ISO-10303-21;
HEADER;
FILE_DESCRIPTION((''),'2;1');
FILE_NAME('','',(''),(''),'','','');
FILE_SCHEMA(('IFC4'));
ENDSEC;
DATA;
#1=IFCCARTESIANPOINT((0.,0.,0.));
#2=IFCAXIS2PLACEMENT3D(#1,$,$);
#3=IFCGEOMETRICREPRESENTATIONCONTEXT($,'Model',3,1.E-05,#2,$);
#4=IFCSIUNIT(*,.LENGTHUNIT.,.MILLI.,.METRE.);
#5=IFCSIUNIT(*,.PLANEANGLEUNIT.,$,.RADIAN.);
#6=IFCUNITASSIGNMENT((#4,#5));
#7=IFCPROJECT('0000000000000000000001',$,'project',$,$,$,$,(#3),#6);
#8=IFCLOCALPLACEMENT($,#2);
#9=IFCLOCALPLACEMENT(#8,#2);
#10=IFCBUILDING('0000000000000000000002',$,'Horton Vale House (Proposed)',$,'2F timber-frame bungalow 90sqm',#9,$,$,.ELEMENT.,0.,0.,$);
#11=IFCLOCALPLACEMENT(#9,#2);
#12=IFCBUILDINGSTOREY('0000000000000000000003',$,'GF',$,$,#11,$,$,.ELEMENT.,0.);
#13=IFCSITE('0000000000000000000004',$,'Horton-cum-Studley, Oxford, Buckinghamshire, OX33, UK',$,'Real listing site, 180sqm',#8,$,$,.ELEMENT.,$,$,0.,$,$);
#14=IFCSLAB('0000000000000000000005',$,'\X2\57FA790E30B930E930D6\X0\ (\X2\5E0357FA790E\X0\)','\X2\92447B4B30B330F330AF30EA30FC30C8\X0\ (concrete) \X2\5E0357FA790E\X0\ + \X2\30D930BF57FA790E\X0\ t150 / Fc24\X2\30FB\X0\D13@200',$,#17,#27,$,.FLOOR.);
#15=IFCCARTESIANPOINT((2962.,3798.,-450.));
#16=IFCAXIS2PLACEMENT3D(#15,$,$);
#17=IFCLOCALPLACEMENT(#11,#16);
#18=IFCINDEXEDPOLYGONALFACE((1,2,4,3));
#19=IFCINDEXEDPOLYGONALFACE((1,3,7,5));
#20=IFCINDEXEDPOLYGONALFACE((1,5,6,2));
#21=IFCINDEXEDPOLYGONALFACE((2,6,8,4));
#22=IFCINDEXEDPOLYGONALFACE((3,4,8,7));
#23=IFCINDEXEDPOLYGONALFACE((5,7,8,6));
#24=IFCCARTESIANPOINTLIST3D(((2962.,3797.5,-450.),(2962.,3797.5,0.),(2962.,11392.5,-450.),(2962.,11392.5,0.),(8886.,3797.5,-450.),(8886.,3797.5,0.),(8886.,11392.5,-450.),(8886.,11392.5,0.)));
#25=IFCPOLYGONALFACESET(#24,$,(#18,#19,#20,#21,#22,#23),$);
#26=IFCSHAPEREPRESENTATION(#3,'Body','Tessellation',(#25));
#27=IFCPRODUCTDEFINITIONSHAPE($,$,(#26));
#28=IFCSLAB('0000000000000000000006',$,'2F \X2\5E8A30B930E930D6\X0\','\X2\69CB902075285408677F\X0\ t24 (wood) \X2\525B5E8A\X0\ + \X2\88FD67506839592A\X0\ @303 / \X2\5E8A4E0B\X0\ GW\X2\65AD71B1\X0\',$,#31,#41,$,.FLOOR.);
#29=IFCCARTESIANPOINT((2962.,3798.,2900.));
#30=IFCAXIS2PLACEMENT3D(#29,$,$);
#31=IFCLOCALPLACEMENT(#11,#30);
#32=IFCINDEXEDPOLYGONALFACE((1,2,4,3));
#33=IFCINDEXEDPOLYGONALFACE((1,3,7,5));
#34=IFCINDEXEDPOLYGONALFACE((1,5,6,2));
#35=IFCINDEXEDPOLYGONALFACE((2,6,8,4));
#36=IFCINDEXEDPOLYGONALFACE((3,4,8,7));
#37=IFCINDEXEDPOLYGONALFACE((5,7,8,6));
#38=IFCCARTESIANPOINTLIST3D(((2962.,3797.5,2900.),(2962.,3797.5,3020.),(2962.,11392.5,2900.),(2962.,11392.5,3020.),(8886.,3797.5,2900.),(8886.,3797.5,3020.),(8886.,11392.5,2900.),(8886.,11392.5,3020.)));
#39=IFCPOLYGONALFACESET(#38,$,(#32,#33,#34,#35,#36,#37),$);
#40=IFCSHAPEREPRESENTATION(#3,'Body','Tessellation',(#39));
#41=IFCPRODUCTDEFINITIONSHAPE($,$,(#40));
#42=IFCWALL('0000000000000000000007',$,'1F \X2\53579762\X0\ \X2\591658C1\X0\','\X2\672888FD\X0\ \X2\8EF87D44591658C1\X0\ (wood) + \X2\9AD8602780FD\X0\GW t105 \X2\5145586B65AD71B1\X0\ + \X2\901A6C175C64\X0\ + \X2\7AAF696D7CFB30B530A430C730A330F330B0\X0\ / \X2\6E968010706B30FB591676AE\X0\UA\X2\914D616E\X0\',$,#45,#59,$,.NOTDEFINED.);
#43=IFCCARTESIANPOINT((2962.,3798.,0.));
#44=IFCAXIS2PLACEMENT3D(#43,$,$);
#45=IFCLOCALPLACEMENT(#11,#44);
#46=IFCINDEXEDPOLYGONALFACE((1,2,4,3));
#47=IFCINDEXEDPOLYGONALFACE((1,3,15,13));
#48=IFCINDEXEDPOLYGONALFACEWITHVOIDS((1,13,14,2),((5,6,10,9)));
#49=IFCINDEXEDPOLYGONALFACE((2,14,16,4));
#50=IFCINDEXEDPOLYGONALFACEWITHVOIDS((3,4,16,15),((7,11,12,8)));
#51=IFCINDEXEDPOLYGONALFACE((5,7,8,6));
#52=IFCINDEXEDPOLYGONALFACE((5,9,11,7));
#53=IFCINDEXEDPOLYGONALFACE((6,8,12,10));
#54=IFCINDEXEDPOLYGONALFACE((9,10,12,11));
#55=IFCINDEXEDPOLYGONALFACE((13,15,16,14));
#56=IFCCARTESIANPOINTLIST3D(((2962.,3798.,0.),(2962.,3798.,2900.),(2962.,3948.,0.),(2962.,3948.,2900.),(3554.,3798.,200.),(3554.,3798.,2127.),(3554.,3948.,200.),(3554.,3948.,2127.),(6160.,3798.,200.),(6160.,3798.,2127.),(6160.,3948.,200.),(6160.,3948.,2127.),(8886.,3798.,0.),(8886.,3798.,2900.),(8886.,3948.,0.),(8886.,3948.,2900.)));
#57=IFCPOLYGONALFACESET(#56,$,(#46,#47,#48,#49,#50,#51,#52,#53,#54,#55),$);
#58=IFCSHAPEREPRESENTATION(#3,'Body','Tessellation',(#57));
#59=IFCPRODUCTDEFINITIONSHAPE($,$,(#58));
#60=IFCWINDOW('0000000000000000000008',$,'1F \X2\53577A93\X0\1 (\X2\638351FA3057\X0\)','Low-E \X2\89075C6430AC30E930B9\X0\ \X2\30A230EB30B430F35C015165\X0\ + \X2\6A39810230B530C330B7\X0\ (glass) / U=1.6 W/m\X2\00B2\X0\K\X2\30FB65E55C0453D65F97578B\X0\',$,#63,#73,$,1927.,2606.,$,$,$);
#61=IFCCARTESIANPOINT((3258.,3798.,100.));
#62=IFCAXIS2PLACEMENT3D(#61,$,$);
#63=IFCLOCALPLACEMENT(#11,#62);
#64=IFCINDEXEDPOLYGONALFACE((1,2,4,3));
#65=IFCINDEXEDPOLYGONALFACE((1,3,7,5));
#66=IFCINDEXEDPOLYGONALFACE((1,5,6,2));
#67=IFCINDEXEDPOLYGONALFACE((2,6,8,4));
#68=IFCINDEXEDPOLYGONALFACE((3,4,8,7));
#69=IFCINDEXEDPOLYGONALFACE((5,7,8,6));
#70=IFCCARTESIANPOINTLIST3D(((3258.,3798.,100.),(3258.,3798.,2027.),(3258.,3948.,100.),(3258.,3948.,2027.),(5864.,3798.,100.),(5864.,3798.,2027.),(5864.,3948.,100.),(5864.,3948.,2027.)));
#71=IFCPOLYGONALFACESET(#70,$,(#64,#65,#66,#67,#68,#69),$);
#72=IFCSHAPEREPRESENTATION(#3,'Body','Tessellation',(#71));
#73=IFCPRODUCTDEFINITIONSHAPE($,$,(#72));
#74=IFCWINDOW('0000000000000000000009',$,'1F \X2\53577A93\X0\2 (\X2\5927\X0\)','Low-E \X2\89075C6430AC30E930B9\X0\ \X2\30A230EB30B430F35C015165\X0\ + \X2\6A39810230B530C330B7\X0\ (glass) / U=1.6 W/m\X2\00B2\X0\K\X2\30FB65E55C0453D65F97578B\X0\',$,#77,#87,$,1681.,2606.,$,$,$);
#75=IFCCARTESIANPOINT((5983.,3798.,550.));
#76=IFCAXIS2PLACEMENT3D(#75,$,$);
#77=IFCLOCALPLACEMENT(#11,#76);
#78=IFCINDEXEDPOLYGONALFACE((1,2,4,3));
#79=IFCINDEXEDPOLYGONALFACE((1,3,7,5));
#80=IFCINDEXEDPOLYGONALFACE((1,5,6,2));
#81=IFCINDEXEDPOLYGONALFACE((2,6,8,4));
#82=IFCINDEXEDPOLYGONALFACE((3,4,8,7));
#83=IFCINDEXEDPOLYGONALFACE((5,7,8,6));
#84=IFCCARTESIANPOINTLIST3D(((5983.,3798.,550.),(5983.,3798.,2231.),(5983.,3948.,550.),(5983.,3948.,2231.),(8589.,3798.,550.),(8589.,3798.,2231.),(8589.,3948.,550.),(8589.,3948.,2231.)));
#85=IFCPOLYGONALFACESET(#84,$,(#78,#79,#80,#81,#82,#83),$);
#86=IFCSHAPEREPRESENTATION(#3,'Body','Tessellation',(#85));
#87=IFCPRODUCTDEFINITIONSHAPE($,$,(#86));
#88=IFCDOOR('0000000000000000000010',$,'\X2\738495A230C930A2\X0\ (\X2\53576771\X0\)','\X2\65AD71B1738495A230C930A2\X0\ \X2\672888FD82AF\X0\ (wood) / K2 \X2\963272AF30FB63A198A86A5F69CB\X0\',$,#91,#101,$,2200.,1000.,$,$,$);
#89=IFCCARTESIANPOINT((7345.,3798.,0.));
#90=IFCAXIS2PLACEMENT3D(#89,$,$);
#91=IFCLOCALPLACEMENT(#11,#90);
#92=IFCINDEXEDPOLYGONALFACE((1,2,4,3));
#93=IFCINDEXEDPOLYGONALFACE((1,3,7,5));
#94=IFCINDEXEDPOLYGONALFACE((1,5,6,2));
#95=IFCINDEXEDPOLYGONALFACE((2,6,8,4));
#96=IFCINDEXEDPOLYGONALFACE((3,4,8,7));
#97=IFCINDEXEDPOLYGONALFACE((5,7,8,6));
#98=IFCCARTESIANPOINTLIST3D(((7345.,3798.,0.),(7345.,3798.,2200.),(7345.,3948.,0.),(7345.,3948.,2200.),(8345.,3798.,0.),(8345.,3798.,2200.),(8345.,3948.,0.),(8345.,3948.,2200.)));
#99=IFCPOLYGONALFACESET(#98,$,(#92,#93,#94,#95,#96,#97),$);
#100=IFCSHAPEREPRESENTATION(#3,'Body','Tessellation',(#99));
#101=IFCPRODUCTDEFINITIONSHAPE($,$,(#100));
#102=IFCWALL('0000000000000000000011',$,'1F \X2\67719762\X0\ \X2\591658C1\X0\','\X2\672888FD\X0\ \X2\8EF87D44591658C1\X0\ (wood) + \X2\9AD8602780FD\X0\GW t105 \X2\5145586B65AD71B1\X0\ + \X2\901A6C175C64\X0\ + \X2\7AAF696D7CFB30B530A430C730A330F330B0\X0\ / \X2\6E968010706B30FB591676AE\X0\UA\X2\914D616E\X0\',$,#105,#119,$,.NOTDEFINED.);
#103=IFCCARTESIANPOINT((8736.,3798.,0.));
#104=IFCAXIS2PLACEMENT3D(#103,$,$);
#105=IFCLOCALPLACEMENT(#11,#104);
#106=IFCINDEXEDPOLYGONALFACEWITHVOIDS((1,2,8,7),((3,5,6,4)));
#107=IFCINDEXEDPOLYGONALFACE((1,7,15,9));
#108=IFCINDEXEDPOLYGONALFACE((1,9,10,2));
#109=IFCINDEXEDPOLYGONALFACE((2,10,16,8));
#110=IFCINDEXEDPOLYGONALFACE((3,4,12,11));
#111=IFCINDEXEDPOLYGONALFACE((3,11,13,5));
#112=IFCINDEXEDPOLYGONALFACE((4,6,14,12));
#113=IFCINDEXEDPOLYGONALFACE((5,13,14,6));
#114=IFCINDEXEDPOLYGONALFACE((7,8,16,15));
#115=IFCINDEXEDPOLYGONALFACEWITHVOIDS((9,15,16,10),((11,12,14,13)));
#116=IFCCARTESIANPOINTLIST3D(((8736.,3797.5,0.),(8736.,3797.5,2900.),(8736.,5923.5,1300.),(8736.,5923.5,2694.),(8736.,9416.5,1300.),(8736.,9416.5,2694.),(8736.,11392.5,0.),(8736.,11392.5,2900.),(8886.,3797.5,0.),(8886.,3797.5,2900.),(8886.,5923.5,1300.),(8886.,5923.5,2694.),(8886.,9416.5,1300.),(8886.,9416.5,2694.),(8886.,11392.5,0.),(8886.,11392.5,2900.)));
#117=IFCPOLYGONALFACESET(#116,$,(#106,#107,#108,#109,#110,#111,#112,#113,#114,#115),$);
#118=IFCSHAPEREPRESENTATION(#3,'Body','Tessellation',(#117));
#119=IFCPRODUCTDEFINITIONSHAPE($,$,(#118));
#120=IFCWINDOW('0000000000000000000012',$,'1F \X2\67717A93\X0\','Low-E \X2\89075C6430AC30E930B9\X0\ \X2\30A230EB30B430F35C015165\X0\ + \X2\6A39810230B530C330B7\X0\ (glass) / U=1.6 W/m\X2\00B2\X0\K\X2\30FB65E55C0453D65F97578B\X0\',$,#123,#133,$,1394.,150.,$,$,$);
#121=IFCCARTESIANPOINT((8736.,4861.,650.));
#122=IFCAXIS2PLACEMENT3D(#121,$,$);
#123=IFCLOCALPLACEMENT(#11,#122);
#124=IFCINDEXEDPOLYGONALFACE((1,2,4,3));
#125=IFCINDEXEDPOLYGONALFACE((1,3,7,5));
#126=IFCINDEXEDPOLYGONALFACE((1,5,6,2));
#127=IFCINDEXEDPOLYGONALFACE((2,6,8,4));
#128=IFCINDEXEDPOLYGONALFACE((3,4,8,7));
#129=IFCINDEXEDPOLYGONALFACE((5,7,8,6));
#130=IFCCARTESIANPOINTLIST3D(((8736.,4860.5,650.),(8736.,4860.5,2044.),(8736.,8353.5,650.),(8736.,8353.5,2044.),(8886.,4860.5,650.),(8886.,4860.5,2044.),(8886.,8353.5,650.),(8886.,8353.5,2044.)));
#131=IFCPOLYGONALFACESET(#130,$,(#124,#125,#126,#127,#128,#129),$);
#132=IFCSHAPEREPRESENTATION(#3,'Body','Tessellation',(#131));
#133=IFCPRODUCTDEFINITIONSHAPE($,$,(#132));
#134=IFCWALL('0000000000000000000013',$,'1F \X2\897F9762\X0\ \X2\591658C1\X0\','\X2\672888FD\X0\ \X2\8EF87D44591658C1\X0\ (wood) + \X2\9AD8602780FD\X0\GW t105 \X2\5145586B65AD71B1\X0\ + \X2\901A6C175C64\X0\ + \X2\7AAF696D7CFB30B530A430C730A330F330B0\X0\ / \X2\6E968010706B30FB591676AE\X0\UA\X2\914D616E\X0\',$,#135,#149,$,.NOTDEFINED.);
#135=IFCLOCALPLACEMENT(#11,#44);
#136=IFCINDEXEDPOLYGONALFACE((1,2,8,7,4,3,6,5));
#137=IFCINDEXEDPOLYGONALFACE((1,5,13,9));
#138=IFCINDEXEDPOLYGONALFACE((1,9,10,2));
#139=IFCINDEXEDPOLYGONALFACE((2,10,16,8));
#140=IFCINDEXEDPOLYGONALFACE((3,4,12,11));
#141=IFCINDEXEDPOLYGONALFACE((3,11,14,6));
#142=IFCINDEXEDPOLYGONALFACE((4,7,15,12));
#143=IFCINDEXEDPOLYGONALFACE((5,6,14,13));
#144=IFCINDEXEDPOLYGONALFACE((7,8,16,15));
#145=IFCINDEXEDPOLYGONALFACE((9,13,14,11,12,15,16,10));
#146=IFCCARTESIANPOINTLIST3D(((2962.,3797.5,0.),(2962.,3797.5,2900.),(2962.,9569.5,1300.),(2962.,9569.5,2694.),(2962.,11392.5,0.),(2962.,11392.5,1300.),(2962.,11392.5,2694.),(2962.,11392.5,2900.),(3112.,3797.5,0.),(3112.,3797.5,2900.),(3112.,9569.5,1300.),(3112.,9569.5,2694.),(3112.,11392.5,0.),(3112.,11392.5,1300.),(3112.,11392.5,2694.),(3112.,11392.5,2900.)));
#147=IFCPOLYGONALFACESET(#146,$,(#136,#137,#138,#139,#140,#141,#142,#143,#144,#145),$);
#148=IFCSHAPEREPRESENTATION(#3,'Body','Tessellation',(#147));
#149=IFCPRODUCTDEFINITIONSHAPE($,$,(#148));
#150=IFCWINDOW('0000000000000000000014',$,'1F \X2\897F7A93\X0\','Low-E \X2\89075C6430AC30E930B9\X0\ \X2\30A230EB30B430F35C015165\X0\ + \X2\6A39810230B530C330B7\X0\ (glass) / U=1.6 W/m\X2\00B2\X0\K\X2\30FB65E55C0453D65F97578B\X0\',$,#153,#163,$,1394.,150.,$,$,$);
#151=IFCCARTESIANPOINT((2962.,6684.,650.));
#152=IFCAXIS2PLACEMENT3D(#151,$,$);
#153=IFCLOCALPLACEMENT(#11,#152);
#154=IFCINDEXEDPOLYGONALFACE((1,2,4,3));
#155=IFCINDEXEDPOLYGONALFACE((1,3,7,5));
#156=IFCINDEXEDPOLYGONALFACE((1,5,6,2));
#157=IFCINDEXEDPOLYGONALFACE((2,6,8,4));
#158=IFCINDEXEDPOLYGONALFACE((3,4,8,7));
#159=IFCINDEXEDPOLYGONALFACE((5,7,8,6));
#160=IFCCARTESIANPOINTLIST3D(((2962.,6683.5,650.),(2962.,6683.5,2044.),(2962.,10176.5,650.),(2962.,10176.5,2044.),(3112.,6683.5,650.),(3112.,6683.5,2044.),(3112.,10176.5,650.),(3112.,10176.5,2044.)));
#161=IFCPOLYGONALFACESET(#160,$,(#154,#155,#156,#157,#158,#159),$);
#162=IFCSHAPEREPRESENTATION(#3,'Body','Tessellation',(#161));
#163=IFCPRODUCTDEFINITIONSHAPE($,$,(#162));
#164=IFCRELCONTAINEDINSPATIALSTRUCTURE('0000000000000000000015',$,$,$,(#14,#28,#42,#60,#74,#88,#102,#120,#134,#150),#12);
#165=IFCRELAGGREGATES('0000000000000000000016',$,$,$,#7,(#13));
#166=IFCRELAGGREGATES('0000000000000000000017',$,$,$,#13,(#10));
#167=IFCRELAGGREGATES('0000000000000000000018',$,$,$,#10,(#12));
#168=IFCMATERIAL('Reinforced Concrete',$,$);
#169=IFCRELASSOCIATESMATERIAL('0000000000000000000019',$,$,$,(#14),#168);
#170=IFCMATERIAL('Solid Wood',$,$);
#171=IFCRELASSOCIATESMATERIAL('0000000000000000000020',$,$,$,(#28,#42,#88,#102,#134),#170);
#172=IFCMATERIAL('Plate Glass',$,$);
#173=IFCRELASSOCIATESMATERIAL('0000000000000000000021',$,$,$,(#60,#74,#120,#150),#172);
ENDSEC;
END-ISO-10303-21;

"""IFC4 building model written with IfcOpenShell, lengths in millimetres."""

from ifc_helpers import new_model, si_unit, frame, frame_2d, origin, place, context, project, spatial, rectangle, extrude, material, element, fill, save


model = new_model("IFC4")

# Units and contexts
model_context = context("Model", 3, precision=1e-05, world=origin())
ifc_project = project(units=[si_unit("LENGTHUNIT", "METRE", prefix="MILLI"), si_unit("PLANEANGLEUNIT", "RADIAN")], contexts=[model_context])

# Site, building, storey
site_placement = place(None, origin())
site = spatial("IfcSite", under=ifc_project, at=site_placement, Name="Horton-cum-Studley, Oxford, Buckinghamshire, OX33, UK", ObjectType="Real listing site, 180sqm", CompositionType="ELEMENT", RefElevation=0.0)
building_placement = place(site_placement, origin())
building = spatial("IfcBuilding", under=site, at=building_placement, Name="Horton Vale House (Proposed)", ObjectType="2F timber-frame bungalow 90sqm", CompositionType="ELEMENT", ElevationOfRefHeight=0.0, ElevationOfTerrain=0.0)
storey_placement = place(building_placement, origin())
storey = spatial("IfcBuildingStorey", under=building, at=storey_placement, Name="GF", CompositionType="ELEMENT", Elevation=0.0)

# Slabs
ifc_material_1 = material(Name="Reinforced Concrete")
slab_1_placement = place(storey_placement, frame((2962.0, 3798.0, -450.0)))
element("IfcSlab", 1, at=slab_1_placement, inside=storey, material=ifc_material_1, Name="基礎スラブ (布基礎)", Description="鉄筋コンクリート (concrete) 布基礎 + ベタ基礎 t150 / Fc24・D13@200", PredefinedType="FLOOR", context=model_context, shape_type="SweptSolid", body=[
    extrude(rectangle(XDim=5924.0, YDim=7595.0, at=frame_2d((2962.0, 3797.0))), frame((2962.0, 3798.0, -450.0)), (0.0, 0.0, 1.0), 450.0),
])
ifc_material_2 = material(Name="Solid Wood")
slab_2_placement = place(storey_placement, frame((2962.0, 3798.0, 2900.0)))
element("IfcSlab", 2, at=slab_2_placement, inside=storey, material=ifc_material_2, Name="2F 床スラブ", Description="構造用合板 t24 (wood) 剛床 + 製材根太 @303 / 床下 GW断熱", PredefinedType="FLOOR", context=model_context, shape_type="SweptSolid", body=[
    extrude(rectangle(XDim=5924.0, YDim=7595.0, at=frame_2d((2962.0, 3797.0))), frame((2962.0, 3798.0, 2900.0)), (0.0, 0.0, 1.0), 120.0),
])

# Wall, openings, windows, door
wall_1_placement = place(storey_placement, frame((2962.0, 3798.0, 0.0)))
wall_1 = element("IfcWall", 3, at=wall_1_placement, inside=storey, material=ifc_material_2, Name="1F 南面 外壁", Description="木製 軸組外壁 (wood) + 高性能GW t105 充填断熱 + 通気層 + 窯業系サイディング / 準耐火・外皮UA配慮", PredefinedType="NOTDEFINED", context=model_context, shape_type="SweptSolid", body=[
    extrude(rectangle(XDim=5924.0, YDim=150.0, at=frame_2d((2962.0, 75.0))), frame((2962.0, 3798.0, 0.0)), (0.0, 0.0, 1.0), 2900.0),
])
opening_1_placement = place(storey_placement, frame((3258.0, 3798.0, 100.0)))
opening_1 = element("IfcOpeningElement", 4, at=opening_1_placement, cuts=wall_1, PredefinedType="NOTDEFINED", context=model_context, shape_type="SweptSolid", body=[
    extrude(rectangle(XDim=2606.0, YDim=150.0, at=frame_2d((1303.0, 75.0))), frame((3258.0, 3798.0, 100.0)), (0.0, 0.0, 1.0), 1927.0),
])
opening_2_placement = place(storey_placement, frame((5983.0, 3798.0, 550.0)))
opening_2 = element("IfcOpeningElement", 5, at=opening_2_placement, cuts=wall_1, PredefinedType="NOTDEFINED", context=model_context, shape_type="SweptSolid", body=[
    extrude(rectangle(XDim=2606.0, YDim=150.0, at=frame_2d((1303.0, 75.0))), frame((5983.0, 3798.0, 550.0)), (0.0, 0.0, 1.0), 1681.0),
])
opening_3_placement = place(storey_placement, frame((7345.0, 3798.0, 0.0)))
opening_3 = element("IfcOpeningElement", 6, at=opening_3_placement, cuts=wall_1, PredefinedType="NOTDEFINED", context=model_context, shape_type="SweptSolid", body=[
    extrude(rectangle(XDim=1000.0, YDim=150.0, at=frame_2d((500.0, 75.0))), frame((7345.0, 3798.0, 0.0)), (0.0, 0.0, 1.0), 2200.0),
])
ifc_material_3 = material(Name="Plate Glass")
window_1_placement = place(storey_placement, frame((3258.0, 3798.0, 100.0)))
window_1 = element("IfcWindow", 7, at=window_1_placement, inside=storey, material=ifc_material_3, Name="1F 南窓1 (掃出し)", Description="Low-E 複層ガラス アルゴン封入 + 樹脂サッシ (glass) / U=1.6 W/m²K・日射取得型", OverallHeight=1927.0, OverallWidth=2606.0, context=model_context, shape_type="SweptSolid", body=[
    extrude(rectangle(XDim=2606.0, YDim=150.0, at=frame_2d((1303.0, 75.0))), frame((3258.0, 3798.0, 100.0)), (0.0, 0.0, 1.0), 1927.0),
])
fill(opening_1, window_1)
window_2_placement = place(storey_placement, frame((5983.0, 3798.0, 550.0)))
window_2 = element("IfcWindow", 8, at=window_2_placement, inside=storey, material=ifc_material_3, Name="1F 南窓2 (大)", Description="Low-E 複層ガラス アルゴン封入 + 樹脂サッシ (glass) / U=1.6 W/m²K・日射取得型", OverallHeight=1681.0, OverallWidth=2606.0, context=model_context, shape_type="SweptSolid", body=[
    extrude(rectangle(XDim=2606.0, YDim=150.0, at=frame_2d((1303.0, 75.0))), frame((5983.0, 3798.0, 550.0)), (0.0, 0.0, 1.0), 1681.0),
])
fill(opening_2, window_2)
door_placement = place(storey_placement, frame((7345.0, 3798.0, 0.0)))
door = element("IfcDoor", 9, at=door_placement, inside=storey, material=ifc_material_2, Name="玄関ドア (南東)", Description="断熱玄関ドア 木製芯 (wood) / K2 防犯・採風機構", OverallHeight=2200.0, OverallWidth=1000.0, context=model_context, shape_type="SweptSolid", body=[
    extrude(rectangle(XDim=1000.0, YDim=150.0, at=frame_2d((500.0, 75.0))), frame((7345.0, 3798.0, 0.0)), (0.0, 0.0, 1.0), 2200.0),
])
fill(opening_3, door)

# Walls, openings, windows
wall_2_placement = place(storey_placement, frame((8736.0, 3798.0, 0.0)))
wall_2 = element("IfcWall", 10, at=wall_2_placement, inside=storey, material=ifc_material_2, Name="1F 東面 外壁", Description="木製 軸組外壁 (wood) + 高性能GW t105 充填断熱 + 通気層 + 窯業系サイディング / 準耐火・外皮UA配慮", PredefinedType="NOTDEFINED", context=model_context, shape_type="SweptSolid", body=[
    extrude(rectangle(XDim=150.0, YDim=7595.0, at=frame_2d((75.0, 3797.0))), frame((8736.0, 3798.0, 0.0)), (0.0, 0.0, 1.0), 2900.0),
])
opening_4_placement = place(storey_placement, frame((8736.0, 4861.0, 650.0)))
opening_4 = element("IfcOpeningElement", 11, at=opening_4_placement, cuts=wall_2, PredefinedType="NOTDEFINED", context=model_context, shape_type="SweptSolid", body=[
    extrude(rectangle(XDim=150.0, YDim=3493.0, at=frame_2d((75.0, 1746.0))), frame((8736.0, 4861.0, 650.0)), (0.0, 0.0, 1.0), 1394.0),
])
window_3_placement = place(storey_placement, frame((8736.0, 4861.0, 650.0)))
window_3 = element("IfcWindow", 12, at=window_3_placement, inside=storey, material=ifc_material_3, Name="1F 東窓", Description="Low-E 複層ガラス アルゴン封入 + 樹脂サッシ (glass) / U=1.6 W/m²K・日射取得型", OverallHeight=1394.0, OverallWidth=150.0, context=model_context, shape_type="SweptSolid", body=[
    extrude(rectangle(XDim=150.0, YDim=3493.0, at=frame_2d((75.0, 1746.0))), frame((8736.0, 4861.0, 650.0)), (0.0, 0.0, 1.0), 1394.0),
])
fill(opening_4, window_3)
wall_3_placement = place(storey_placement, frame((2962.0, 3798.0, 0.0)))
wall_3 = element("IfcWall", 13, at=wall_3_placement, inside=storey, material=ifc_material_2, Name="1F 西面 外壁", Description="木製 軸組外壁 (wood) + 高性能GW t105 充填断熱 + 通気層 + 窯業系サイディング / 準耐火・外皮UA配慮", PredefinedType="NOTDEFINED", context=model_context, shape_type="SweptSolid", body=[
    extrude(rectangle(XDim=150.0, YDim=7595.0, at=frame_2d((75.0, 3797.0))), frame((2962.0, 3798.0, 0.0)), (0.0, 0.0, 1.0), 2900.0),
])
opening_5_placement = place(storey_placement, frame((2962.0, 6684.0, 650.0)))
opening_5 = element("IfcOpeningElement", 14, at=opening_5_placement, cuts=wall_3, PredefinedType="NOTDEFINED", context=model_context, shape_type="SweptSolid", body=[
    extrude(rectangle(XDim=150.0, YDim=3493.0, at=frame_2d((75.0, 1746.0))), frame((2962.0, 6684.0, 650.0)), (0.0, 0.0, 1.0), 1394.0),
])
window_4_placement = place(storey_placement, frame((2962.0, 6684.0, 650.0)))
window_4 = element("IfcWindow", 15, at=window_4_placement, inside=storey, material=ifc_material_3, Name="1F 西窓", Description="Low-E 複層ガラス アルゴン封入 + 樹脂サッシ (glass) / U=1.6 W/m²K・日射取得型", OverallHeight=1394.0, OverallWidth=150.0, context=model_context, shape_type="SweptSolid", body=[
    extrude(rectangle(XDim=150.0, YDim=3493.0, at=frame_2d((75.0, 1746.0))), frame((2962.0, 6684.0, 650.0)), (0.0, 0.0, 1.0), 1394.0),
])
fill(opening_5, window_4)

save(model, "model.ifc")
